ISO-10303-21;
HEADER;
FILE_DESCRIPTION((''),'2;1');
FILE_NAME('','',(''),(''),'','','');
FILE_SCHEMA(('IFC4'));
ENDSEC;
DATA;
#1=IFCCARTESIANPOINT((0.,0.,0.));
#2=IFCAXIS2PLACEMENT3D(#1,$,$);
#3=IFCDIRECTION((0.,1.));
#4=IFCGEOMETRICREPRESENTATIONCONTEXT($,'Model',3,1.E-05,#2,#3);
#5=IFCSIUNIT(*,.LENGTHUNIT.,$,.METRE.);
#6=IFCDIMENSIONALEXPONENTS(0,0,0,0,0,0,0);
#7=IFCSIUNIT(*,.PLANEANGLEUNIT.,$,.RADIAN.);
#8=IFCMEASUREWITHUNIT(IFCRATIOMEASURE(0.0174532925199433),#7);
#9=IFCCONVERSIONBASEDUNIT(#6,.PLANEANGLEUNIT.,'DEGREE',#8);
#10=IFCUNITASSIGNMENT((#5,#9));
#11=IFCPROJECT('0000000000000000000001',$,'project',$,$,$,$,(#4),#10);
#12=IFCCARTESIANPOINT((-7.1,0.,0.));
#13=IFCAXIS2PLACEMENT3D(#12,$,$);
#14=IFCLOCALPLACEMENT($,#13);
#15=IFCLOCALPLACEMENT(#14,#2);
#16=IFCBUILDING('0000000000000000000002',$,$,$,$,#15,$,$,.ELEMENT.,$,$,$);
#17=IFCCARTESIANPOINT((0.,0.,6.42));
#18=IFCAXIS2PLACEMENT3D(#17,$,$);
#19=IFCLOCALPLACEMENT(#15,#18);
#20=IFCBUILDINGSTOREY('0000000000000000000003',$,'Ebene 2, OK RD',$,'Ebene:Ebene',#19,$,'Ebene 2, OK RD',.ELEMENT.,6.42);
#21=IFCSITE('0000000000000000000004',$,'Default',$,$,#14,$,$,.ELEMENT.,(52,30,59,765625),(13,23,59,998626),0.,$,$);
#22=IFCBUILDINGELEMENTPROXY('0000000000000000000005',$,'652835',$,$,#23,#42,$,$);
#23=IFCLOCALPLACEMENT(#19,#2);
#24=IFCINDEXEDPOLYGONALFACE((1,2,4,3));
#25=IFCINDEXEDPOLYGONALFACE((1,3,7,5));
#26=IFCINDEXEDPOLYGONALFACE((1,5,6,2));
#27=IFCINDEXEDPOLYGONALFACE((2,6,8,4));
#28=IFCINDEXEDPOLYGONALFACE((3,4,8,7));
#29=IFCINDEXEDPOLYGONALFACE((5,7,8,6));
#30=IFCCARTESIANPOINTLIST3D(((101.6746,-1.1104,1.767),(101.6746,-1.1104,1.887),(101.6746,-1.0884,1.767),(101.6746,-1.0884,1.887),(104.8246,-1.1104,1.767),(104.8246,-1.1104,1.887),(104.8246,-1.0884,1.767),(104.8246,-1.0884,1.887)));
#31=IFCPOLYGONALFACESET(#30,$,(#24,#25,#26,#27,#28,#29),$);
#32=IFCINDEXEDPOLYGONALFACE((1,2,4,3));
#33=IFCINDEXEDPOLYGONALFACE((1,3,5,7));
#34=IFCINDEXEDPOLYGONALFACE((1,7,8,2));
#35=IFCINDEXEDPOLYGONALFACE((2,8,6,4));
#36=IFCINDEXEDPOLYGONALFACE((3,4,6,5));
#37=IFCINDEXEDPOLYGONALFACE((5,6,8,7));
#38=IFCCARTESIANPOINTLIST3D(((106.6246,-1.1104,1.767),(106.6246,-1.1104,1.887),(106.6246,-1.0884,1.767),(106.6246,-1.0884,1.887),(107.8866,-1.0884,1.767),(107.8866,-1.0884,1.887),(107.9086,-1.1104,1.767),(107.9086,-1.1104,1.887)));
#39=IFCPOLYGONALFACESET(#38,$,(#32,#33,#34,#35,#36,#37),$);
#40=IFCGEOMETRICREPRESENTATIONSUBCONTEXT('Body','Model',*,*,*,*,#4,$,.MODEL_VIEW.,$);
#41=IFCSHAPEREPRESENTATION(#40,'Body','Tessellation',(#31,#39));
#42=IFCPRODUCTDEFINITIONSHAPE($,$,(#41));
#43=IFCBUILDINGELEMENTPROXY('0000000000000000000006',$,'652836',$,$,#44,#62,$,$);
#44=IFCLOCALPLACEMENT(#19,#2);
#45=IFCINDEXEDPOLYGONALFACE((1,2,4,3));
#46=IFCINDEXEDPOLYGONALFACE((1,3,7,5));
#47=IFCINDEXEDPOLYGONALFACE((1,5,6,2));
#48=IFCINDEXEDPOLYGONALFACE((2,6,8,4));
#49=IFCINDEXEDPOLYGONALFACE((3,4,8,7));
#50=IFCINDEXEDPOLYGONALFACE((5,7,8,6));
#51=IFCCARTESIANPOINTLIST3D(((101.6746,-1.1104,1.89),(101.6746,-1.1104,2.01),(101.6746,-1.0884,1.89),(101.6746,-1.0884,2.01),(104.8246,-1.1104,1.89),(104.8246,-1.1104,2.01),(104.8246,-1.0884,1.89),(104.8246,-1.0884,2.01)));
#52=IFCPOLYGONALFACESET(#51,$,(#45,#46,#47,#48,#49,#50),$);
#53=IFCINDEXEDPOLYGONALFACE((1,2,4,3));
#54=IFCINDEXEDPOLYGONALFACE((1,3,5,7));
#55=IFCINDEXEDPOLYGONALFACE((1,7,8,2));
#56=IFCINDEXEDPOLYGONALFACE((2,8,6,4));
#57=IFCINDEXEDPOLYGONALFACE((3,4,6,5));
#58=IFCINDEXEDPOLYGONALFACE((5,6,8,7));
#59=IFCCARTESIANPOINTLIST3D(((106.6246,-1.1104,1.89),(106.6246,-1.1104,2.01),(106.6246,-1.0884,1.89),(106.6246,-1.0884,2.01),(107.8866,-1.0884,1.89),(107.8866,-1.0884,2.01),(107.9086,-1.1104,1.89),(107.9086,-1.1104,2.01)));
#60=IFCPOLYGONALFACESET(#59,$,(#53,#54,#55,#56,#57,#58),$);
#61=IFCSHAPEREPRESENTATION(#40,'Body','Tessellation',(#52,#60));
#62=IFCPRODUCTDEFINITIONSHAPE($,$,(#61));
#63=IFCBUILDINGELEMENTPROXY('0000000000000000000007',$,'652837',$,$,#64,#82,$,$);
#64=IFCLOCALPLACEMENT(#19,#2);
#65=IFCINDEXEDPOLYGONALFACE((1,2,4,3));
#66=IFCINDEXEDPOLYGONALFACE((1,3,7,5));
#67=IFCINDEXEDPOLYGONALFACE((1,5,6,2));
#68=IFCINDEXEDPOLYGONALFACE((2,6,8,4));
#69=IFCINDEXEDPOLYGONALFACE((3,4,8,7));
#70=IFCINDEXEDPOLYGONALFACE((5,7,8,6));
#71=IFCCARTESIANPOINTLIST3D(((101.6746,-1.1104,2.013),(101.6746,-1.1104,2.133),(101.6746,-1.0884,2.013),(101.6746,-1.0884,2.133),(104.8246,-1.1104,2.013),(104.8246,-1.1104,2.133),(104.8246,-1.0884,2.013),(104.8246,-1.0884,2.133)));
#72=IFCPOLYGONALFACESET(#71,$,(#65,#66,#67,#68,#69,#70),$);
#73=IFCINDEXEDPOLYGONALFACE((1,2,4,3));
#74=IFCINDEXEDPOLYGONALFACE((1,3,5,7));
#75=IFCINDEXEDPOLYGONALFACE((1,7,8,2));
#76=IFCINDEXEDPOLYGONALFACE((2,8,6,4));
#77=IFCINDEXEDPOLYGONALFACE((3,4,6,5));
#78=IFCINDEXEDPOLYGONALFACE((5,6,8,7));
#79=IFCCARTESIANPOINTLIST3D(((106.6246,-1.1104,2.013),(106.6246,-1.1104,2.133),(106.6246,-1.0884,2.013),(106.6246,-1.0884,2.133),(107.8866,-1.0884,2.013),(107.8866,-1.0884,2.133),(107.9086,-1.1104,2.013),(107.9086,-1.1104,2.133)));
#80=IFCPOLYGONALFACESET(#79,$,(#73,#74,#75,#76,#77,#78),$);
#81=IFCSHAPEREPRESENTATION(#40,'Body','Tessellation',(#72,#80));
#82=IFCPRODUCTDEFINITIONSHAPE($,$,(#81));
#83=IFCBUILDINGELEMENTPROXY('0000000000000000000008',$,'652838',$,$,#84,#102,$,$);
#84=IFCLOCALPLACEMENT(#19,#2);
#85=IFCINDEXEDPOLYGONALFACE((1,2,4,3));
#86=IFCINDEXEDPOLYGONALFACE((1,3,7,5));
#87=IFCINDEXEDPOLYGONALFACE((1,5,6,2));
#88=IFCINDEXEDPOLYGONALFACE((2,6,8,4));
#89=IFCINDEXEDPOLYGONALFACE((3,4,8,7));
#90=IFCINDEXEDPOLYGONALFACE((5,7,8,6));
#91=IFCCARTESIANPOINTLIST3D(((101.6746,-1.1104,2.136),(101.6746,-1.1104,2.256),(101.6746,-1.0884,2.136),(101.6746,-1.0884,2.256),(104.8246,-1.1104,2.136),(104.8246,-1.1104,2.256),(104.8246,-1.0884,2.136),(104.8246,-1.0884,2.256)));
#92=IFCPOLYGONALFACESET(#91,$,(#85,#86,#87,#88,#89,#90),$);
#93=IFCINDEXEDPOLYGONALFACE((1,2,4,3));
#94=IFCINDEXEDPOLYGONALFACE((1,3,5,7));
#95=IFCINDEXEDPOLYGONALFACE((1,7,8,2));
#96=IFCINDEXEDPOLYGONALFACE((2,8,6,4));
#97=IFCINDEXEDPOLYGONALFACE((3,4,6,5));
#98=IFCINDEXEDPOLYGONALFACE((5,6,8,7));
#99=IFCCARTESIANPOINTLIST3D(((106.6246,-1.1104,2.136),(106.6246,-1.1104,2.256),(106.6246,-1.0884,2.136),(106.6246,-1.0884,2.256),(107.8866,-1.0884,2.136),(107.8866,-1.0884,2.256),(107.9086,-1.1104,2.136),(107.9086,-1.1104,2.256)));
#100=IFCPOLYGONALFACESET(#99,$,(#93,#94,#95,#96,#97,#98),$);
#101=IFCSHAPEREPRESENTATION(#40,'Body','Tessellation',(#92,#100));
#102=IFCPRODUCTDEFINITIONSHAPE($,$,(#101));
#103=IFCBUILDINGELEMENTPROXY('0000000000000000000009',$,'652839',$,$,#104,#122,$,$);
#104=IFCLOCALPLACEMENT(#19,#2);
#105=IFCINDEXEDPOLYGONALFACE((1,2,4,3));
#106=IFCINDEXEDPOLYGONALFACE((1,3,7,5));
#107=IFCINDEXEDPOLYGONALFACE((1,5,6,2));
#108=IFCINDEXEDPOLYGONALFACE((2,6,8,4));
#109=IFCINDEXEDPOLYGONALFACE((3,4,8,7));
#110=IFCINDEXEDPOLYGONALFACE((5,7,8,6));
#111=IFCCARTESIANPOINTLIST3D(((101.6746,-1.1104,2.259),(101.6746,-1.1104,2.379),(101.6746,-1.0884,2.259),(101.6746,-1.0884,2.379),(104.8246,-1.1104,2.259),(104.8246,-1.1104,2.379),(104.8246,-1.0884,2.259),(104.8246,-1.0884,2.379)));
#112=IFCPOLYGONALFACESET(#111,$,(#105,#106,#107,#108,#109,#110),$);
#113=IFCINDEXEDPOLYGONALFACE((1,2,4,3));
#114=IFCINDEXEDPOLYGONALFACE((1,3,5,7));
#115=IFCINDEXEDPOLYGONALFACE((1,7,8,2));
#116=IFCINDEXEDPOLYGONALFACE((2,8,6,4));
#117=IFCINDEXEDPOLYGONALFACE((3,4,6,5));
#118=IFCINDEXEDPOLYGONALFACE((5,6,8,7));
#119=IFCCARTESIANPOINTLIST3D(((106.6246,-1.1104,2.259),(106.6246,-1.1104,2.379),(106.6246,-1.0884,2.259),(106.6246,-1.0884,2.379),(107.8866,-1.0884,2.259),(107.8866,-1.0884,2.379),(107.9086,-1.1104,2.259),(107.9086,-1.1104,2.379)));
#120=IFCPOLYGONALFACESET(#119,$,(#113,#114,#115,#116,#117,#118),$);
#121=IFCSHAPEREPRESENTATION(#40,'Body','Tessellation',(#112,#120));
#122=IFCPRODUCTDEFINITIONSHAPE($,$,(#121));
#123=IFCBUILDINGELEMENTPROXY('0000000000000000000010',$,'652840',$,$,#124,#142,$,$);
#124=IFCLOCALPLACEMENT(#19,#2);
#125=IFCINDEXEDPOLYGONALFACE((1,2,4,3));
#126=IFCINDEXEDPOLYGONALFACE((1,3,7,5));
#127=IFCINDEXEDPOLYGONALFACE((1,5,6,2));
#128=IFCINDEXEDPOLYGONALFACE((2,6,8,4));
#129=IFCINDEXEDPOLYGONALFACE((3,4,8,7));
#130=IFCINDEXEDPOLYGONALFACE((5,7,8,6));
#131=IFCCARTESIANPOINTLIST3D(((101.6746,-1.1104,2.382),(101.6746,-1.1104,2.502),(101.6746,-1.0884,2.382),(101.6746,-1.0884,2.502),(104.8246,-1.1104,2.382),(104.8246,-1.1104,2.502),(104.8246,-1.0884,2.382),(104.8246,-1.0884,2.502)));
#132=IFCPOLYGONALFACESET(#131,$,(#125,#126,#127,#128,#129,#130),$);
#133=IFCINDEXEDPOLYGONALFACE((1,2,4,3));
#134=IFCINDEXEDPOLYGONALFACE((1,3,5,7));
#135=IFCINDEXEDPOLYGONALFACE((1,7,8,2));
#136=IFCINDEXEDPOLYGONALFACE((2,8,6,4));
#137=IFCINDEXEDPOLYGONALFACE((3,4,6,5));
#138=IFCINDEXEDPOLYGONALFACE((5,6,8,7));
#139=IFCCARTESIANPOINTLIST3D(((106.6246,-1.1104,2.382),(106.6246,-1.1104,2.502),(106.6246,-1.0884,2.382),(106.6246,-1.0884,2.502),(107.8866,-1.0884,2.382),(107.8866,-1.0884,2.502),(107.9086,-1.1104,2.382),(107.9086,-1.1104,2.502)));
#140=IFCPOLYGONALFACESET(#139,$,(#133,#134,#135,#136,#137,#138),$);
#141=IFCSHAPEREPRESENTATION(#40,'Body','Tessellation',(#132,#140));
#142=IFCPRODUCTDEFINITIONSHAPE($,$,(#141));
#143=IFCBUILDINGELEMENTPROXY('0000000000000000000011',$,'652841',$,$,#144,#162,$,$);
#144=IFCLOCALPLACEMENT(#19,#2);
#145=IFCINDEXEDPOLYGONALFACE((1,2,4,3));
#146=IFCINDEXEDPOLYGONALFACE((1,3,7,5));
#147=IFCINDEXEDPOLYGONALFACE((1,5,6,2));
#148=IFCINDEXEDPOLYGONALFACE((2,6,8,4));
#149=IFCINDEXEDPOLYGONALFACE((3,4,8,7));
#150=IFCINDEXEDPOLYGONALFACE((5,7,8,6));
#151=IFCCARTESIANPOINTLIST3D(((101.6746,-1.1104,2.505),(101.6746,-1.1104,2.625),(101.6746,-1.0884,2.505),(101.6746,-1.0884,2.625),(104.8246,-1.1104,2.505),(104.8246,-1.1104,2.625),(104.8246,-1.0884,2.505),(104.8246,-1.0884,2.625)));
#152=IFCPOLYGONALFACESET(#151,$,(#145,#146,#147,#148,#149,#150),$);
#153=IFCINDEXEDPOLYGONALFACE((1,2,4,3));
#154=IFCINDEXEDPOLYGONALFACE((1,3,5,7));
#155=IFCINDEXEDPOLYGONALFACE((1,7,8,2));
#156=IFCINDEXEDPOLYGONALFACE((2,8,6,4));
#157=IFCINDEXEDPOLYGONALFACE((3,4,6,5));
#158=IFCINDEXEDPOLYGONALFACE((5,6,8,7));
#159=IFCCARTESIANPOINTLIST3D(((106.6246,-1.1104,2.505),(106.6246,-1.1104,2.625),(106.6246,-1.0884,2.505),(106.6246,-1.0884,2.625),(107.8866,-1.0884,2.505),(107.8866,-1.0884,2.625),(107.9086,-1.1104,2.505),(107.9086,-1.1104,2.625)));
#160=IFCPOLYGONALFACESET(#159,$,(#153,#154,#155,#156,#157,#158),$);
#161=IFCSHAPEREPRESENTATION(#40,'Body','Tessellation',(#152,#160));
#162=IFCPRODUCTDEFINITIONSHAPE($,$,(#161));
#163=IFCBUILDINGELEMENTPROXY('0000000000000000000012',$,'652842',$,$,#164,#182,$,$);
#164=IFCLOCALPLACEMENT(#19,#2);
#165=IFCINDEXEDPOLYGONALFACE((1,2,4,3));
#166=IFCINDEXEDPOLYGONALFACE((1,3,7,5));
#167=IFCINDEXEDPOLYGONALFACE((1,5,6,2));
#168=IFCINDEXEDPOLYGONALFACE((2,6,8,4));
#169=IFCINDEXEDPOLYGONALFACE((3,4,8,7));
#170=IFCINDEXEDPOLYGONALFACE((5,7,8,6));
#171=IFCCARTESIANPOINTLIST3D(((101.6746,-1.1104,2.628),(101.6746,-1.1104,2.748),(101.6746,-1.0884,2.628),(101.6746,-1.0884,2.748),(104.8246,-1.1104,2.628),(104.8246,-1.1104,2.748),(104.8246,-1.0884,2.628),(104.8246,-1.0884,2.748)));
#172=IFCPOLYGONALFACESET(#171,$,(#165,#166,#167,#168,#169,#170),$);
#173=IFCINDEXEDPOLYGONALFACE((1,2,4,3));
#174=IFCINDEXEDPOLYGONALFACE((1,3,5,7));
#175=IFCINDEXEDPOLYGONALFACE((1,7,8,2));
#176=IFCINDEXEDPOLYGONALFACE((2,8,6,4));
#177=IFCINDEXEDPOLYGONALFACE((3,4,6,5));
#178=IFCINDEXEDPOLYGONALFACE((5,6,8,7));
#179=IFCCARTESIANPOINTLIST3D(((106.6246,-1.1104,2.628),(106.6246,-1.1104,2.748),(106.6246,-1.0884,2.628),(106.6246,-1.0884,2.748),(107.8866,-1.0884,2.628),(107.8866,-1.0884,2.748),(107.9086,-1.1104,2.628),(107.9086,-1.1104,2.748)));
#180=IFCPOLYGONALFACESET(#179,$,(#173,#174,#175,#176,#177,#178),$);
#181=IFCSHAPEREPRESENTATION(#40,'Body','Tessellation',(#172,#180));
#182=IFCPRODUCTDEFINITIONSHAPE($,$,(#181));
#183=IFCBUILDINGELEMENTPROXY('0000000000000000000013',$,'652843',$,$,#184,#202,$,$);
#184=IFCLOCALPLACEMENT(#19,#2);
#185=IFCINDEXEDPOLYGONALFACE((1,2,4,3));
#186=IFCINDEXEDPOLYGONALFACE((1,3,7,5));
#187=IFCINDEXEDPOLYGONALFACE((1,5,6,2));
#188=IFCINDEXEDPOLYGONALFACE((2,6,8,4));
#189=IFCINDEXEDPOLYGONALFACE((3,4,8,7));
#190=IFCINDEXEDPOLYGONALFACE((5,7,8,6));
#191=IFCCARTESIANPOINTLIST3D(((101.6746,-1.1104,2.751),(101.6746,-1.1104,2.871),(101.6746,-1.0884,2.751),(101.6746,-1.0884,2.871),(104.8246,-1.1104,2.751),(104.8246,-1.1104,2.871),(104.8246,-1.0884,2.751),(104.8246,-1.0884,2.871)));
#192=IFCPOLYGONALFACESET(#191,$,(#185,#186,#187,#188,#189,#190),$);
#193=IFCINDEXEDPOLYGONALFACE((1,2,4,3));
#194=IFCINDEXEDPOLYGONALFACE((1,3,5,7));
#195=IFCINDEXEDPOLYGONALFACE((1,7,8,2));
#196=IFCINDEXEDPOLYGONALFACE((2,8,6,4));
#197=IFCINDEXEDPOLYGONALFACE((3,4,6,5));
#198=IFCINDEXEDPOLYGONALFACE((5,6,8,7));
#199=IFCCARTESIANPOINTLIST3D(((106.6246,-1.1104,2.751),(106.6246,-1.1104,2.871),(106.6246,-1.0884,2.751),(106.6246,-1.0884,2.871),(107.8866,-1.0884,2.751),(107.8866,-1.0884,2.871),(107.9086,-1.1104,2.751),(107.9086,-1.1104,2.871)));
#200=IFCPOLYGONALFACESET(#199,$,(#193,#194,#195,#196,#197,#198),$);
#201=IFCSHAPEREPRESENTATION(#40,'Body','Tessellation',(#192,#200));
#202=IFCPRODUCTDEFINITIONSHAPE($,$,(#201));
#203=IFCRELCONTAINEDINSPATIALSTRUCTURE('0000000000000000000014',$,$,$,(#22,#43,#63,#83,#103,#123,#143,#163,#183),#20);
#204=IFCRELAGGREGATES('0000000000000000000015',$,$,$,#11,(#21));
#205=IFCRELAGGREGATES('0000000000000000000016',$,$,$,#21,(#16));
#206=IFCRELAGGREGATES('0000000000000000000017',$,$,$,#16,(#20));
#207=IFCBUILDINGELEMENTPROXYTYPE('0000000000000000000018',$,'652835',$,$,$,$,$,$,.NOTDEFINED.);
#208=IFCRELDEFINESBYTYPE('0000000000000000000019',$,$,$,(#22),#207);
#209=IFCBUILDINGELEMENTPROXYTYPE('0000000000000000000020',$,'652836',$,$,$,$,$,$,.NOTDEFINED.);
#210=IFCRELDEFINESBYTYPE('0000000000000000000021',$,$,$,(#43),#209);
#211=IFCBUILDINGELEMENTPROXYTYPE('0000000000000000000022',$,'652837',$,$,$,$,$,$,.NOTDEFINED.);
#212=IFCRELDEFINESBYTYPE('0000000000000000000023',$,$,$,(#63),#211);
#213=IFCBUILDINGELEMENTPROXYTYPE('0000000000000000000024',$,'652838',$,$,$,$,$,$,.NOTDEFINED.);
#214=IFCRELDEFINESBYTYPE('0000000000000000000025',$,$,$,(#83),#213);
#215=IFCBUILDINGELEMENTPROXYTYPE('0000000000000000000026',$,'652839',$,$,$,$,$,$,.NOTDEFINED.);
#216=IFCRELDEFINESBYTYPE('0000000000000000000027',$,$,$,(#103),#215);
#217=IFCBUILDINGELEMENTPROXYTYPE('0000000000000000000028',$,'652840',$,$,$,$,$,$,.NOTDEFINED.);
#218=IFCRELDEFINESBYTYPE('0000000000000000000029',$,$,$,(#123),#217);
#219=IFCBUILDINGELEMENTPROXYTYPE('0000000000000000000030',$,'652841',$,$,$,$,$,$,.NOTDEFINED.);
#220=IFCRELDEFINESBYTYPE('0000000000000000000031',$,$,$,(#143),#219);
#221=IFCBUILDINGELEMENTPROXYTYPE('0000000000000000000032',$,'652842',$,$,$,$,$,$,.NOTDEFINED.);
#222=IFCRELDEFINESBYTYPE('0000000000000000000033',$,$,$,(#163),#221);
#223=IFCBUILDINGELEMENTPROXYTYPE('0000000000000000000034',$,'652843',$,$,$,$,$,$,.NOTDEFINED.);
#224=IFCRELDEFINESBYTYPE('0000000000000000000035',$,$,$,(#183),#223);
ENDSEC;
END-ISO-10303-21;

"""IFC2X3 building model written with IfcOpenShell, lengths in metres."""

from ifc_helpers import new_model, entity, si_unit, converted_unit, direction, frame, origin, origin_2d_with_axis, place, context, subcontext, project, spatial, polyline, rectangle, outline, extrude, type_object, element, save


model = new_model("IFC2X3")

# Units and contexts
model_context = context("Model", 3, precision=1e-05, world=origin(), true_north=direction((0.0, 1.0)))
body_context = subcontext(model_context, "Body", "Model", "MODEL_VIEW")
ifc_project = project(units=[si_unit("LENGTHUNIT", "METRE"), converted_unit("PLANEANGLEUNIT", "DEGREE", entity("IfcRatioMeasure", 0.0174532925199433), si_unit("PLANEANGLEUNIT", "RADIAN"), dimensions=[0, 0, 0, 0, 0, 0, 0])], contexts=[model_context])

# Site, building, storey
site_placement = place(None, frame((-7.1, 0.0, 0.0)))
site = spatial("IfcSite", under=ifc_project, at=site_placement, Name="Default", CompositionType="ELEMENT", RefLatitude=(52, 30, 59, 765625), RefLongitude=(13, 23, 59, 998626), RefElevation=0.0)
building_placement = place(site_placement, origin())
building = spatial("IfcBuilding", under=site, at=building_placement, CompositionType="ELEMENT")
storey_placement = place(building_placement, frame((0.0, 0.0, 6.42)))
storey = spatial("IfcBuildingStorey", under=building, at=storey_placement, Name="Ebene 2, OK RD", ObjectType="Ebene:Ebene", LongName="Ebene 2, OK RD", CompositionType="ELEMENT", Elevation=6.42)

# Building element proxies
building_element_proxy_type_1 = type_object("IfcBuildingElementProxyType", Name="652835", PredefinedType="NOTDEFINED")
proxy_1_placement = place(storey_placement, origin())
element("IfcBuildingElementProxy", 1, at=proxy_1_placement, inside=storey, type_object=building_element_proxy_type_1, Name="652835", context=body_context, shape_type="SweptSolid", body=[
    extrude(rectangle(XDim=3.15, YDim=0.022, at=origin_2d_with_axis()), frame((103.2496, -1.0994, 1.767), z_axis=(0.0, 0.0, 1.0), x_axis=(-1.0, 0.0, 0.0)), (0.0, 0.0, 1.0), 0.12),
    extrude(outline(polyline([(-0.6255, -0.011), (0.6365, -0.011), (0.6365, 0.011), (-0.6475, 0.011), (-0.6255, -0.011)])), frame((107.2611, -1.0994, 1.767), z_axis=(0.0, 0.0, 1.0), x_axis=(-1.0, 0.0, 0.0)), (0.0, 0.0, 1.0), 0.12),
])
building_element_proxy_type_2 = type_object("IfcBuildingElementProxyType", Name="652836", PredefinedType="NOTDEFINED")
proxy_2_placement = place(storey_placement, origin())
element("IfcBuildingElementProxy", 2, at=proxy_2_placement, inside=storey, type_object=building_element_proxy_type_2, Name="652836", context=body_context, shape_type="SweptSolid", body=[
    extrude(rectangle(XDim=3.15, YDim=0.022, at=origin_2d_with_axis()), frame((103.2496, -1.0994, 1.89), z_axis=(0.0, 0.0, 1.0), x_axis=(-1.0, 0.0, 0.0)), (0.0, 0.0, 1.0), 0.12),
    extrude(outline(polyline([(-0.6255, -0.011), (0.6365, -0.011), (0.6365, 0.011), (-0.6475, 0.011), (-0.6255, -0.011)])), frame((107.2611, -1.0994, 1.89), z_axis=(0.0, 0.0, 1.0), x_axis=(-1.0, 0.0, 0.0)), (0.0, 0.0, 1.0), 0.12),
])
building_element_proxy_type_3 = type_object("IfcBuildingElementProxyType", Name="652837", PredefinedType="NOTDEFINED")
proxy_3_placement = place(storey_placement, origin())
element("IfcBuildingElementProxy", 3, at=proxy_3_placement, inside=storey, type_object=building_element_proxy_type_3, Name="652837", context=body_context, shape_type="SweptSolid", body=[
    extrude(rectangle(XDim=3.15, YDim=0.022, at=origin_2d_with_axis()), frame((103.2496, -1.0994, 2.013), z_axis=(0.0, 0.0, 1.0), x_axis=(-1.0, 0.0, 0.0)), (0.0, 0.0, 1.0), 0.12),
    extrude(outline(polyline([(-0.6255, -0.011), (0.6365, -0.011), (0.6365, 0.011), (-0.6475, 0.011), (-0.6255, -0.011)])), frame((107.2611, -1.0994, 2.013), z_axis=(0.0, 0.0, 1.0), x_axis=(-1.0, 0.0, 0.0)), (0.0, 0.0, 1.0), 0.12),
])
building_element_proxy_type_4 = type_object("IfcBuildingElementProxyType", Name="652838", PredefinedType="NOTDEFINED")
proxy_4_placement = place(storey_placement, origin())
element("IfcBuildingElementProxy", 4, at=proxy_4_placement, inside=storey, type_object=building_element_proxy_type_4, Name="652838", context=body_context, shape_type="SweptSolid", body=[
    extrude(rectangle(XDim=3.15, YDim=0.022, at=origin_2d_with_axis()), frame((103.2496, -1.0994, 2.136), z_axis=(0.0, 0.0, 1.0), x_axis=(-1.0, 0.0, 0.0)), (0.0, 0.0, 1.0), 0.12),
    extrude(outline(polyline([(-0.6255, -0.011), (0.6365, -0.011), (0.6365, 0.011), (-0.6475, 0.011), (-0.6255, -0.011)])), frame((107.2611, -1.0994, 2.136), z_axis=(0.0, 0.0, 1.0), x_axis=(-1.0, 0.0, 0.0)), (0.0, 0.0, 1.0), 0.12),
])
building_element_proxy_type_5 = type_object("IfcBuildingElementProxyType", Name="652839", PredefinedType="NOTDEFINED")
proxy_5_placement = place(storey_placement, origin())
element("IfcBuildingElementProxy", 5, at=proxy_5_placement, inside=storey, type_object=building_element_proxy_type_5, Name="652839", context=body_context, shape_type="SweptSolid", body=[
    extrude(rectangle(XDim=3.15, YDim=0.022, at=origin_2d_with_axis()), frame((103.2496, -1.0994, 2.259), z_axis=(0.0, 0.0, 1.0), x_axis=(-1.0, 0.0, 0.0)), (0.0, 0.0, 1.0), 0.12),
    extrude(outline(polyline([(-0.6255, -0.011), (0.6365, -0.011), (0.6365, 0.011), (-0.6475, 0.011), (-0.6255, -0.011)])), frame((107.2611, -1.0994, 2.259), z_axis=(0.0, 0.0, 1.0), x_axis=(-1.0, 0.0, 0.0)), (0.0, 0.0, 1.0), 0.12),
])
building_element_proxy_type_6 = type_object("IfcBuildingElementProxyType", Name="652840", PredefinedType="NOTDEFINED")
proxy_6_placement = place(storey_placement, origin())
element("IfcBuildingElementProxy", 6, at=proxy_6_placement, inside=storey, type_object=building_element_proxy_type_6, Name="652840", context=body_context, shape_type="SweptSolid", body=[
    extrude(rectangle(XDim=3.15, YDim=0.022, at=origin_2d_with_axis()), frame((103.2496, -1.0994, 2.382), z_axis=(0.0, 0.0, 1.0), x_axis=(-1.0, 0.0, 0.0)), (0.0, 0.0, 1.0), 0.12),
    extrude(outline(polyline([(-0.6255, -0.011), (0.6365, -0.011), (0.6365, 0.011), (-0.6475, 0.011), (-0.6255, -0.011)])), frame((107.2611, -1.0994, 2.382), z_axis=(0.0, 0.0, 1.0), x_axis=(-1.0, 0.0, 0.0)), (0.0, 0.0, 1.0), 0.12),
])
building_element_proxy_type_7 = type_object("IfcBuildingElementProxyType", Name="652841", PredefinedType="NOTDEFINED")
proxy_7_placement = place(storey_placement, origin())
element("IfcBuildingElementProxy", 7, at=proxy_7_placement, inside=storey, type_object=building_element_proxy_type_7, Name="652841", context=body_context, shape_type="SweptSolid", body=[
    extrude(rectangle(XDim=3.15, YDim=0.022, at=origin_2d_with_axis()), frame((103.2496, -1.0994, 2.505), z_axis=(0.0, 0.0, 1.0), x_axis=(-1.0, 0.0, 0.0)), (0.0, 0.0, 1.0), 0.12),
    extrude(outline(polyline([(-0.6255, -0.011), (0.6365, -0.011), (0.6365, 0.011), (-0.6475, 0.011), (-0.6255, -0.011)])), frame((107.2611, -1.0994, 2.505), z_axis=(0.0, 0.0, 1.0), x_axis=(-1.0, 0.0, 0.0)), (0.0, 0.0, 1.0), 0.12),
])
building_element_proxy_type_8 = type_object("IfcBuildingElementProxyType", Name="652842", PredefinedType="NOTDEFINED")
proxy_8_placement = place(storey_placement, origin())
element("IfcBuildingElementProxy", 8, at=proxy_8_placement, inside=storey, type_object=building_element_proxy_type_8, Name="652842", context=body_context, shape_type="SweptSolid", body=[
    extrude(rectangle(XDim=3.15, YDim=0.022, at=origin_2d_with_axis()), frame((103.2496, -1.0994, 2.628), z_axis=(0.0, 0.0, 1.0), x_axis=(-1.0, 0.0, 0.0)), (0.0, 0.0, 1.0), 0.12),
    extrude(outline(polyline([(-0.6255, -0.011), (0.6365, -0.011), (0.6365, 0.011), (-0.6475, 0.011), (-0.6255, -0.011)])), frame((107.2611, -1.0994, 2.628), z_axis=(0.0, 0.0, 1.0), x_axis=(-1.0, 0.0, 0.0)), (0.0, 0.0, 1.0), 0.12),
])
building_element_proxy_type_9 = type_object("IfcBuildingElementProxyType", Name="652843", PredefinedType="NOTDEFINED")
proxy_9_placement = place(storey_placement, origin())
element("IfcBuildingElementProxy", 9, at=proxy_9_placement, inside=storey, type_object=building_element_proxy_type_9, Name="652843", context=body_context, shape_type="SweptSolid", body=[
    extrude(rectangle(XDim=3.15, YDim=0.022, at=origin_2d_with_axis()), frame((103.2496, -1.0994, 2.751), z_axis=(0.0, 0.0, 1.0), x_axis=(-1.0, 0.0, 0.0)), (0.0, 0.0, 1.0), 0.12),
    extrude(outline(polyline([(-0.6255, -0.011), (0.6365, -0.011), (0.6365, 0.011), (-0.6475, 0.011), (-0.6255, -0.011)])), frame((107.2611, -1.0994, 2.751), z_axis=(0.0, 0.0, 1.0), x_axis=(-1.0, 0.0, 0.0)), (0.0, 0.0, 1.0), 0.12),
])

save(model, "model.ifc")
